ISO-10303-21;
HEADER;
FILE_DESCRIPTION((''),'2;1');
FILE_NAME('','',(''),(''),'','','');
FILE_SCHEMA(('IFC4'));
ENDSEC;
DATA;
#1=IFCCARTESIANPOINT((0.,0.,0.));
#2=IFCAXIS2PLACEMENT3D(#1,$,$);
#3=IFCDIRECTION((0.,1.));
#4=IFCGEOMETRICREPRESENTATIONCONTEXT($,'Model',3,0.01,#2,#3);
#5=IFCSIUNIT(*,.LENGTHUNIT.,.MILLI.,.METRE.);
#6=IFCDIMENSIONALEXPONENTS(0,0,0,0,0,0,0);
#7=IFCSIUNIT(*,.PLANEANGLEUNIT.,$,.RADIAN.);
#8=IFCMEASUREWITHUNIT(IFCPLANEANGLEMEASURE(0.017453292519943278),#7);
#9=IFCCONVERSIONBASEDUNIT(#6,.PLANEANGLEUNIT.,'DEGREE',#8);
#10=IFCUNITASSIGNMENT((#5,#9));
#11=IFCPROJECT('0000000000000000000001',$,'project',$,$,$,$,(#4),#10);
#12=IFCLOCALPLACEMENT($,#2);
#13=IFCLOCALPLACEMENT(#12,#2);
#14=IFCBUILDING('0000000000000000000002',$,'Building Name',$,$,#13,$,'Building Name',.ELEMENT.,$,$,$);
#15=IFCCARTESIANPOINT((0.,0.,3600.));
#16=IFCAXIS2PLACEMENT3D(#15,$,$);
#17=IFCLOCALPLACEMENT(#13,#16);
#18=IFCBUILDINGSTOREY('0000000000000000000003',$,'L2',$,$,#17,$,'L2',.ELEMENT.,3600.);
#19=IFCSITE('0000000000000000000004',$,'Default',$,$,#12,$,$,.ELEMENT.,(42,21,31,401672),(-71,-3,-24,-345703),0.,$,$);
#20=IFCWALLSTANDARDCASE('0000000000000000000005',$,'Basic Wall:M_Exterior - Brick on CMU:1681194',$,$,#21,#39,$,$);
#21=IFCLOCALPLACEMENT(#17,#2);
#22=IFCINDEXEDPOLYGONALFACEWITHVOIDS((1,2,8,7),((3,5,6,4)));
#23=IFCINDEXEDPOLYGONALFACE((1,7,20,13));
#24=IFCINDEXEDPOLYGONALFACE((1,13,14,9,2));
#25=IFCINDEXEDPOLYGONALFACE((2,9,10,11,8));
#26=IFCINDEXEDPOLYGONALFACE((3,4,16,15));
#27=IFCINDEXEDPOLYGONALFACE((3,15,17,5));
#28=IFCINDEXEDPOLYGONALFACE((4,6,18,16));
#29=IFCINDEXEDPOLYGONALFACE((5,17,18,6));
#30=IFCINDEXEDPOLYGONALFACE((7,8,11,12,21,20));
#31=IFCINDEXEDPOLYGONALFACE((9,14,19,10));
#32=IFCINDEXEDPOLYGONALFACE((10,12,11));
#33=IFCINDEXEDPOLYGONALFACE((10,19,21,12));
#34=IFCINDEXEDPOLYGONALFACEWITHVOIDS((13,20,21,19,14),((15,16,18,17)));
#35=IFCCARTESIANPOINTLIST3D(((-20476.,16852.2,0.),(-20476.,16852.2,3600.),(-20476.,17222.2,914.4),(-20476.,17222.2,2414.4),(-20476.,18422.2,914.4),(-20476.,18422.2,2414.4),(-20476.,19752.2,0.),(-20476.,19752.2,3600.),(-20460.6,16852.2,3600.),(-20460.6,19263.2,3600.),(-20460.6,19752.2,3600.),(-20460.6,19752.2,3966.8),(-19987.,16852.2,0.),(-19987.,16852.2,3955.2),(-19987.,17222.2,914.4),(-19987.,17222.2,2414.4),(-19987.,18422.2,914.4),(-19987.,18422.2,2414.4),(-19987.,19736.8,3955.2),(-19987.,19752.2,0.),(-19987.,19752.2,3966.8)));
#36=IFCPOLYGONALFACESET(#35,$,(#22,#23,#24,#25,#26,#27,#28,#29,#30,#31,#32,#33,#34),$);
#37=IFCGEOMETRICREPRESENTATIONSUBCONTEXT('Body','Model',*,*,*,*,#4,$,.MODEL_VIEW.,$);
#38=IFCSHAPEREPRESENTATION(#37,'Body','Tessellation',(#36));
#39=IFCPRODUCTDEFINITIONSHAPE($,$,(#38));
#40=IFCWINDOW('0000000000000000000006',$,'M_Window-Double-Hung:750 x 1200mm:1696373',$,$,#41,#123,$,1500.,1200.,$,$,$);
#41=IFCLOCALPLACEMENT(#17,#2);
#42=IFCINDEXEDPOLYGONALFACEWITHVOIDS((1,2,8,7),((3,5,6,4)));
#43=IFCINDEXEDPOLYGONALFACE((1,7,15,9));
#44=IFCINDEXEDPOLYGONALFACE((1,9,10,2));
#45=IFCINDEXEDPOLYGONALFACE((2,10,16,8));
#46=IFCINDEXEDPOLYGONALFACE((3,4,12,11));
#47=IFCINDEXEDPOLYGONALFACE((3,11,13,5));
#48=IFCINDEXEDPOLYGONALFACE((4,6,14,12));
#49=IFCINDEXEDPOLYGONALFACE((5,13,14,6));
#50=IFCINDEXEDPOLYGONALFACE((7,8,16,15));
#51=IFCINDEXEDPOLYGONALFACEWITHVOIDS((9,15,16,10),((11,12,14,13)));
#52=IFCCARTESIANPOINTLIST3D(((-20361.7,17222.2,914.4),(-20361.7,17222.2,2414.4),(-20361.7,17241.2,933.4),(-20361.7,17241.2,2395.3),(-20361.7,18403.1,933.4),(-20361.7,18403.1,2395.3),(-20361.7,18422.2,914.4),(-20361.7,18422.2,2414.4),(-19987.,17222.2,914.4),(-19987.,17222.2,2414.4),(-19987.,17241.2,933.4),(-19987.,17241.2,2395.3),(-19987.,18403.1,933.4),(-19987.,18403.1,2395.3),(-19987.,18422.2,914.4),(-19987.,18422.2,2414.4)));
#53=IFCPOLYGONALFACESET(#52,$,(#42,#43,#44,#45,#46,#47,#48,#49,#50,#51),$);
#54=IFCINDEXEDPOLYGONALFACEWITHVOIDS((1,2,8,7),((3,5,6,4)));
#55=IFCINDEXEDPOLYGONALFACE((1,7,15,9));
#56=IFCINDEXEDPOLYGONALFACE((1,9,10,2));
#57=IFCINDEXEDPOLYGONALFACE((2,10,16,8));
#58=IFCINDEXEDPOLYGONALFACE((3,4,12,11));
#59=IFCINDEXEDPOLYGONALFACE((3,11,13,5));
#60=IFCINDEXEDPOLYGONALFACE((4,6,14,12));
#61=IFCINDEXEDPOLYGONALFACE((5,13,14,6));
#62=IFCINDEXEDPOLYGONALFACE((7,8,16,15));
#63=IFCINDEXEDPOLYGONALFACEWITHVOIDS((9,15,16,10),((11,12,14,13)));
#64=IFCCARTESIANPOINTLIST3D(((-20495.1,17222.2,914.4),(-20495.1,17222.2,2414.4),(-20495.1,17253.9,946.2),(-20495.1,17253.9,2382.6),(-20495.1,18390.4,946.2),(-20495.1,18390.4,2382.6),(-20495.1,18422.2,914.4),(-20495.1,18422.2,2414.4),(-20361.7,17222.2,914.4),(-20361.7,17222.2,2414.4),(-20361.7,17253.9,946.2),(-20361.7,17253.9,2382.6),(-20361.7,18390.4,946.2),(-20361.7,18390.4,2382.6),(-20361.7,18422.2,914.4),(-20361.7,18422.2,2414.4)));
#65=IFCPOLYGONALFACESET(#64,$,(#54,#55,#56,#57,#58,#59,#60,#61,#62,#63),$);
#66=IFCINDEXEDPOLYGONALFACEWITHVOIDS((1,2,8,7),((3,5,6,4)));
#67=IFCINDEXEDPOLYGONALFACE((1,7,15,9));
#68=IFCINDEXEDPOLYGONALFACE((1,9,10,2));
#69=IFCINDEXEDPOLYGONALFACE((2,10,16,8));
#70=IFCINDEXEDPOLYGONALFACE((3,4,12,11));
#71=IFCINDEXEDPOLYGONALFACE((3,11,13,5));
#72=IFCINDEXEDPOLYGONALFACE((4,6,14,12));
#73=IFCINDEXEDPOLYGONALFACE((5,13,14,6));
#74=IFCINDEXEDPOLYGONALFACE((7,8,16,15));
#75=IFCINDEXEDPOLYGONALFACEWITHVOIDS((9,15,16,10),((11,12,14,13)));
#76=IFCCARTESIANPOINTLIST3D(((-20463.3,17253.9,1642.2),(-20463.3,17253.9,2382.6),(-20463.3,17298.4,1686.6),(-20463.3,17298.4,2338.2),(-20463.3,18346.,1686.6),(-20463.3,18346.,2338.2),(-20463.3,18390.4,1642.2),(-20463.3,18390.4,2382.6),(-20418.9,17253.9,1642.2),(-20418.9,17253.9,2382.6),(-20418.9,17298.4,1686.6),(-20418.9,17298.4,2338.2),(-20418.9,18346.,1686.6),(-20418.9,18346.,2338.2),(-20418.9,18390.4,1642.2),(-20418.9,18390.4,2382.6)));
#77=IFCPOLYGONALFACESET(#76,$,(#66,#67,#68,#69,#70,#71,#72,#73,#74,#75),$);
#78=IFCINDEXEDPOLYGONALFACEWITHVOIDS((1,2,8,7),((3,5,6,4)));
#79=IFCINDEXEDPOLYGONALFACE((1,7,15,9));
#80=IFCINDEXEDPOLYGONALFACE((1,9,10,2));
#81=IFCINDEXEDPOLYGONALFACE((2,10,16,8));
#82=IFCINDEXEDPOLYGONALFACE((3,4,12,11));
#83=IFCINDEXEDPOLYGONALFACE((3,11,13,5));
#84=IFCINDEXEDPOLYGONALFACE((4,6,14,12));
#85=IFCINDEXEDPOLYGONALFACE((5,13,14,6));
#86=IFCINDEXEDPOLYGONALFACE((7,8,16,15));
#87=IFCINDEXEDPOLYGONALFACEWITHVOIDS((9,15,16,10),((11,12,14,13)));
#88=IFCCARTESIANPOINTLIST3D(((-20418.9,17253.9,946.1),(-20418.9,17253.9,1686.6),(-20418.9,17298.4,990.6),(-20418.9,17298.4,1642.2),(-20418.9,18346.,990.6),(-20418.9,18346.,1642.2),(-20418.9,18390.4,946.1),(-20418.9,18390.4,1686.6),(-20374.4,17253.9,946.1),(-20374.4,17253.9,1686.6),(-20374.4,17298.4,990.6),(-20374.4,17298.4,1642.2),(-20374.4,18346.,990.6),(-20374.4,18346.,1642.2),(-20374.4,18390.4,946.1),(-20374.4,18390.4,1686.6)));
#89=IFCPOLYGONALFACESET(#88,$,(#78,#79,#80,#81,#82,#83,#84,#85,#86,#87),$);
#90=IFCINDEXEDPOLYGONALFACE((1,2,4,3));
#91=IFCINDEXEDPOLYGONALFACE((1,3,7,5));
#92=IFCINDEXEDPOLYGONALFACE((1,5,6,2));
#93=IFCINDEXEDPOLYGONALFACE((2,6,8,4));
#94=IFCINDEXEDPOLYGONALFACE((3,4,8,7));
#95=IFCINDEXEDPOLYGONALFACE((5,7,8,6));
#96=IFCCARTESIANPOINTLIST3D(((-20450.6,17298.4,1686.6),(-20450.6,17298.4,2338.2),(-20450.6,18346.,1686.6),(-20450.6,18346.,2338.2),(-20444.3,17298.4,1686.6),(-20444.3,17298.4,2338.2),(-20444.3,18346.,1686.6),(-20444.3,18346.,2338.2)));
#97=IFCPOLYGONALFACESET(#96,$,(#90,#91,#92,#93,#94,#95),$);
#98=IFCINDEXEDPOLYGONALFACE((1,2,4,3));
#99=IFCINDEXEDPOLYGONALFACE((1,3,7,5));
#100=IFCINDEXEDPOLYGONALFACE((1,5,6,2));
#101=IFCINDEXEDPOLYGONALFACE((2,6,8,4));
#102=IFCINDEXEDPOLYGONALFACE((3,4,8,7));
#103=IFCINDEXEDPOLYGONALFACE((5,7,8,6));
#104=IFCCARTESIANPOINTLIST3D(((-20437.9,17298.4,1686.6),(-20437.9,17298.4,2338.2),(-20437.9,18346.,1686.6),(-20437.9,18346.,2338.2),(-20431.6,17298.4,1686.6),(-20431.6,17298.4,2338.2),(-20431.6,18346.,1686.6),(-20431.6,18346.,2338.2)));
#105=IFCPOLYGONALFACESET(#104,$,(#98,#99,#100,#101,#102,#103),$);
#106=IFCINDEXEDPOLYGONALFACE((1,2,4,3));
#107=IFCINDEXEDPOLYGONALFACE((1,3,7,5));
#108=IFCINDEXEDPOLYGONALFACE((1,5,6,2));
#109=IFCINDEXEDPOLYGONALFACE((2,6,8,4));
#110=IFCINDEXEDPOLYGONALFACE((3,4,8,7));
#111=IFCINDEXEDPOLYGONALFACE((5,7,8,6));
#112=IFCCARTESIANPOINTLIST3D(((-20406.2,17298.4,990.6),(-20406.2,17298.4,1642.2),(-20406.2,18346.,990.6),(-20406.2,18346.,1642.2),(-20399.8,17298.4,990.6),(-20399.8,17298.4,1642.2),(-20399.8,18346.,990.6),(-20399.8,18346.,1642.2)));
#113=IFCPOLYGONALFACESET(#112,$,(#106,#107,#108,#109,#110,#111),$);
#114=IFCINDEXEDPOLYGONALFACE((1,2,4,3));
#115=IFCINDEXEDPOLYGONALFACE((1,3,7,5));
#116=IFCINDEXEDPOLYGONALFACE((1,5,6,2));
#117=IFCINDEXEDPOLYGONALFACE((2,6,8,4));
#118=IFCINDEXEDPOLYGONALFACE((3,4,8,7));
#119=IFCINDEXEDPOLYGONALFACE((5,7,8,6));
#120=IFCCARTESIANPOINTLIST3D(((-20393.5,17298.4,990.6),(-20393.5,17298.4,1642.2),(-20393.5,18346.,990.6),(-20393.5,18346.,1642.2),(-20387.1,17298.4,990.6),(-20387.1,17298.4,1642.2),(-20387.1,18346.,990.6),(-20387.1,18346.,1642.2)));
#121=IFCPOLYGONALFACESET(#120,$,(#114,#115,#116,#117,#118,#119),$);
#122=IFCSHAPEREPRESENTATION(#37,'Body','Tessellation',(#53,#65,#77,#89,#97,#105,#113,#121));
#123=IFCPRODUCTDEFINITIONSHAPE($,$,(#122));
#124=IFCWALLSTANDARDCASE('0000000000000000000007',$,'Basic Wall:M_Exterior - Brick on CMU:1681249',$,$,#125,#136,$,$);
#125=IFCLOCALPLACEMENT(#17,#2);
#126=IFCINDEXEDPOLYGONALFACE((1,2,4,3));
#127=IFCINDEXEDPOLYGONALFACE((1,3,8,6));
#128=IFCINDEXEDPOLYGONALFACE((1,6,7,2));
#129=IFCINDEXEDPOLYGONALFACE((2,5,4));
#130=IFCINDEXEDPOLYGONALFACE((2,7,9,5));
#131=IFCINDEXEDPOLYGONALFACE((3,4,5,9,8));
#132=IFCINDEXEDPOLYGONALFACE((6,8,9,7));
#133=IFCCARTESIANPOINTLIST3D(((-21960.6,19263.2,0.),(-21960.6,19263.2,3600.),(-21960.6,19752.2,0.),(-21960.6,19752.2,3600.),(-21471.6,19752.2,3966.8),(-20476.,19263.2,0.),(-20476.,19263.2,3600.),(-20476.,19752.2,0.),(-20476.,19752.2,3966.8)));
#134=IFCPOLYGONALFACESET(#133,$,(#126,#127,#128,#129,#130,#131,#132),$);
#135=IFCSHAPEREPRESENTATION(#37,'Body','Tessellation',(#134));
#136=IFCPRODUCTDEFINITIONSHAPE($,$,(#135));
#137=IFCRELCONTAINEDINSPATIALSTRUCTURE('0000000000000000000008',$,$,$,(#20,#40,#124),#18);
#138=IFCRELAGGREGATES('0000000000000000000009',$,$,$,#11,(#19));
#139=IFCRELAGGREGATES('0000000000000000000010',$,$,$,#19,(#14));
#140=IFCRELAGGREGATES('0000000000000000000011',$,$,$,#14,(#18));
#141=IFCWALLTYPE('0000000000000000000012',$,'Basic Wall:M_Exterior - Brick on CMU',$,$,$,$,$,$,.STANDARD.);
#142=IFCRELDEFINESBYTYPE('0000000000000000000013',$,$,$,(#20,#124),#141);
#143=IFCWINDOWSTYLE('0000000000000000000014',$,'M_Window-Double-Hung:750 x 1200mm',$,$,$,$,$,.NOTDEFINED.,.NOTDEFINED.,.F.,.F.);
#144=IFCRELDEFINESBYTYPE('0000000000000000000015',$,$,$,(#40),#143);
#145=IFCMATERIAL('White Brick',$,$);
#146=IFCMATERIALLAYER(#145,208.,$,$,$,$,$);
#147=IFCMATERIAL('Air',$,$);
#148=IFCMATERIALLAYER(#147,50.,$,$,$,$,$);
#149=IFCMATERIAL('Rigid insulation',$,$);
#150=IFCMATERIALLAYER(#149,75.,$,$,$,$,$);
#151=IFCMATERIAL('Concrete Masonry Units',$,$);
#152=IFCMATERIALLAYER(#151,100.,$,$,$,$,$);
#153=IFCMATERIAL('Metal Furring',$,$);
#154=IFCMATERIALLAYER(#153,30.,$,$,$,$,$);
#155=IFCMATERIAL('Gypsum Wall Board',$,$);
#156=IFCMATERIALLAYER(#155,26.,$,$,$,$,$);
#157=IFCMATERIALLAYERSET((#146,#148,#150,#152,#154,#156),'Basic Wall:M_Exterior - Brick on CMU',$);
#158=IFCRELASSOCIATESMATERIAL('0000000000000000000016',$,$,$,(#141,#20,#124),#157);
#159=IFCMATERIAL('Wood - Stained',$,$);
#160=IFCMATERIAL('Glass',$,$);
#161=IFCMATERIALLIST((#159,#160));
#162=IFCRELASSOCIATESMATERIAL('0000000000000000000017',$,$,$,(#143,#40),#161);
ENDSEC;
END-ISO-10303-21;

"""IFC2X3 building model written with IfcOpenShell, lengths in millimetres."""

from ifc_helpers import new_model, entity, si_unit, converted_unit, direction, frame, frame_2d, origin, place, context, subcontext, project, spatial, polyline, rectangle, outline, extrude, clip, bounded_halfspace, source, transform, mapped, material, material_list, layer, layer_set, layer_usage, type_object, type_shapes, element, fill, save


model = new_model("IFC2X3")

# Units and contexts
model_context = context("Model", 3, precision=0.01, world=origin(), true_north=direction((0.0, 1.0)))
body_context = subcontext(model_context, "Body", "Model", "MODEL_VIEW")
ifc_project = project(units=[si_unit("LENGTHUNIT", "METRE", prefix="MILLI"), converted_unit("PLANEANGLEUNIT", "DEGREE", entity("IfcPlaneAngleMeasure", 0.017453292519943278), si_unit("PLANEANGLEUNIT", "RADIAN"), dimensions=[0, 0, 0, 0, 0, 0, 0])], contexts=[model_context])

# Site, building, storey
site_placement = place(None, origin())
site = spatial("IfcSite", under=ifc_project, at=site_placement, Name="Default", CompositionType="ELEMENT", RefLatitude=(42, 21, 31, 401672), RefLongitude=(-71, -3, -24, -345703), RefElevation=0.0)
building_placement = place(site_placement, origin())
building = spatial("IfcBuilding", under=site, at=building_placement, Name="Building Name", LongName="Building Name", CompositionType="ELEMENT")
storey_placement = place(building_placement, frame((0.0, 0.0, 3600.0)))
storey = spatial("IfcBuildingStorey", under=building, at=storey_placement, Name="L2", LongName="L2", CompositionType="ELEMENT", Elevation=3600.0)

# Shared definitions
ifc_material_1 = material(Name="White Brick")
ifc_layer_1 = layer(ifc_material_1, 208.0)
ifc_material_2 = material(Name="Air")
ifc_layer_2 = layer(ifc_material_2, 50.0)
ifc_material_3 = material(Name="Rigid insulation")
ifc_layer_3 = layer(ifc_material_3, 75.0)
ifc_material_4 = material(Name="Concrete Masonry Units")
ifc_layer_4 = layer(ifc_material_4, 100.0)
ifc_material_5 = material(Name="Metal Furring")
ifc_layer_5 = layer(ifc_material_5, 30.0)
ifc_material_6 = material(Name="Gypsum Wall Board")
ifc_layer_6 = layer(ifc_material_6, 26.0)
ifc_layer_set_1 = layer_set([ifc_layer_1, ifc_layer_2, ifc_layer_3, ifc_layer_4, ifc_layer_5, ifc_layer_6], Name="Basic Wall:M_Exterior - Brick on CMU")
wall_type_1 = type_object("IfcWallType", Name="Basic Wall:M_Exterior - Brick on CMU", PredefinedType="STANDARD", material=ifc_layer_set_1)
ifc_material_7 = material(Name="Wood - Stained")
ifc_material_8 = material(Name="Glass")
ifc_material_list_1 = material_list([ifc_material_7, ifc_material_8])
window_style = type_object("IfcWindowStyle", Name="M_Window-Double-Hung:750 x 1200mm", ConstructionType="NOTDEFINED", OperationType="NOTDEFINED", ParameterTakesPrecedence=False, Sizeable=False, material=ifc_material_list_1)
shared_shape_1 = source(origin(), body_context, "Body", "SweptSolid", [
    extrude(outline(polyline([(-750.0, -600.0), (750.0, -600.0), (750.0, 600.0), (-750.0, 600.0), (-750.0, -600.0)]), holes=[polyline([(-730.9, -580.9), (-730.9, 580.9), (730.9, 580.9), (730.9, -580.9), (-730.9, -580.9)])]), frame((600.0, 0.0, 750.0), z_axis=(0.0, 1.0, 0.0), x_axis=(0.0, 0.0, -1.0)), (0.0, 0.0, 1.0), 374.7),
    extrude(outline(polyline([(-600.0, -750.0), (600.0, -750.0), (600.0, 750.0), (-600.0, 750.0), (-600.0, -750.0)]), holes=[polyline([(568.2, -718.2), (-568.2, -718.2), (-568.2, 718.2), (568.2, 718.2), (568.2, -718.2)])]), frame((600.0, 374.7, 750.0), z_axis=(0.0, 1.0, 0.0), x_axis=(1.0, 0.0, 0.0)), (0.0, 0.0, 1.0), 133.3),
    extrude(outline(polyline([(-568.2, -370.2), (568.2, -370.2), (568.2, 370.2), (-568.2, 370.2), (-568.2, -370.2)]), holes=[polyline([(523.8, -325.8), (-523.8, -325.8), (-523.8, 325.8), (523.8, 325.8), (523.8, -325.8)])]), frame((600.0, 431.8, 1098.0), z_axis=(0.0, 1.0, 0.0), x_axis=(1.0, 0.0, 0.0)), (0.0, 0.0, 1.0), 44.4),
    extrude(outline(polyline([(-568.2, -370.2), (568.2, -370.2), (568.2, 370.2), (-568.2, 370.2), (-568.2, -370.2)]), holes=[polyline([(523.8, -325.8), (-523.8, -325.8), (-523.8, 325.8), (523.8, 325.8), (523.8, -325.8)])]), frame((600.0, 387.4, 402.0), z_axis=(0.0, 1.0, 0.0), x_axis=(1.0, 0.0, 0.0)), (0.0, 0.0, 1.0), 44.5),
    extrude(rectangle(XDim=1047.6, YDim=6.4, at=frame_2d((0.0, 0.0), x_axis=(1.0, 0.0))), frame((600.0, 460.4, 772.2), z_axis=(0.0, 0.0, 1.0), x_axis=(-1.0, 0.0, 0.0)), (0.0, 0.0, 1.0), 651.6),
    extrude(rectangle(XDim=6.4, YDim=1047.6, at=frame_2d((0.0, 0.0), x_axis=(1.0, 0.0))), frame((600.0, 447.7, 772.2), z_axis=(0.0, 0.0, 1.0), x_axis=(0.0, -1.0, 0.0)), (0.0, 0.0, 1.0), 651.6),
    extrude(rectangle(XDim=1047.6, YDim=6.4, at=frame_2d((0.0, 0.0), x_axis=(1.0, 0.0))), frame((600.0, 416.0, 76.2), z_axis=(0.0, 0.0, 1.0), x_axis=(-1.0, 0.0, 0.0)), (0.0, 0.0, 1.0), 651.6),
    extrude(rectangle(XDim=6.4, YDim=1047.6, at=frame_2d((0.0, 0.0), x_axis=(1.0, 0.0))), frame((600.0, 403.3, 76.2), z_axis=(0.0, 0.0, 1.0), x_axis=(0.0, -1.0, 0.0)), (0.0, 0.0, 1.0), 651.6),
])
type_shapes(window_style, [shared_shape_1])

# Wall, opening, window
ifc_layer_usage_1 = layer_usage(ifc_layer_set_1, "AXIS2", "NEGATIVE", 244.5)
wall_1_placement = place(storey_placement, frame((-20231.5, 16852.2, 0.0), z_axis=(0.0, 0.0, 1.0), x_axis=(0.0, 1.0, 0.0)))
wall_1 = element("IfcWallStandardCase", 1, at=wall_1_placement, inside=storey, type_object=wall_type_1, material=ifc_layer_usage_1, Name="Basic Wall:M_Exterior - Brick on CMU:1681194", context=body_context, shape_type="Clipping", body=[
    clip(clip(clip(extrude(rectangle(XDim=2900.0, YDim=489.0, at=frame_2d((1450.0, 0.0), x_axis=(-1.0, 0.0))), origin(), (0.0, 0.0, 1.0), 3966.8), bounded_halfspace(frame((0.0, -244.5, 3955.2), z_axis=(0.0, 0.6, 0.8), x_axis=(-1.0, 0.0, 0.0)), False, frame((0.0, -244.5, 3955.2)), polyline([(0.0, 0.0), (2884.6, 0.0), (2411.0, 473.6), (0.0, 473.6), (0.0, 0.0)]))), bounded_halfspace(frame((2884.6, -244.5, 3955.2), z_axis=(-0.6, 0.0, 0.8), x_axis=(0.0, -1.0, 0.0)), False, frame((2884.6, -244.5, 3955.2)), polyline([(0.0, 0.0), (15.4, 0.0), (15.4, 473.6), (-473.6, 473.6), (0.0, 0.0)]))), bounded_halfspace(frame((2900.0, 229.1, 3600.0), z_axis=(0.0, 0.0, 1.0), x_axis=(0.0, 1.0, 0.0)), False, frame((2900.0, 229.1, 3600.0)), polyline([(0.0, 0.0), (0.0, 15.4), (-2900.0, 15.4), (-2900.0, 0.0), (-489.0, 0.0), (0.0, 0.0)]))),
])
opening_1_placement = place(wall_1_placement, frame((370.0, -244.5, 914.4)))
opening_1 = element("IfcOpeningElement", 2, at=opening_1_placement, cuts=wall_1, ObjectType="Opening", context=body_context, shape_type="SweptSolid", body=[
    extrude(rectangle(XDim=1500.0, YDim=1200.0, at=frame_2d((750.0, 600.0), x_axis=(-1.0, 0.0))), frame((0.0, 0.0, 0.0), z_axis=(0.0, 1.0, 0.0), x_axis=(0.0, 0.0, 1.0)), (0.0, 0.0, 1.0), 489.0),
])
window_1_placement = place(opening_1_placement, origin())
window_1 = element("IfcWindow", 3, at=window_1_placement, inside=storey, type_object=window_style, material=ifc_material_list_1, Name="M_Window-Double-Hung:750 x 1200mm:1696373", OverallHeight=1500.0, OverallWidth=1200.0, context=body_context, shape_type="MappedRepresentation", body=[
    mapped(shared_shape_1, transform((0.0, 0.0, 0.0), scale=1.0)),
])
fill(opening_1, window_1)

# Wall
ifc_layer_usage_2 = layer_usage(ifc_layer_set_1, "AXIS2", "NEGATIVE", 244.5)
wall_2_placement = place(storey_placement, frame((-20476.0, 19507.7, 0.0), z_axis=(0.0, 0.0, 1.0), x_axis=(-1.0, 0.0, 0.0)))
element("IfcWallStandardCase", 4, at=wall_2_placement, inside=storey, type_object=wall_type_1, material=ifc_layer_usage_2, Name="Basic Wall:M_Exterior - Brick on CMU:1681249", context=body_context, shape_type="Clipping", body=[
    clip(clip(extrude(rectangle(XDim=1484.6, YDim=489.0, at=frame_2d((742.3, 0.0), x_axis=(-1.0, 0.0))), origin(), (0.0, 0.0, 1.0), 3966.8), bounded_halfspace(frame((995.6, -244.5, 3966.8), z_axis=(0.6, 0.0, 0.8), x_axis=(0.0, 1.0, 0.0)), False, frame((995.6, -244.5, 3966.8)), polyline([(0.0, 0.0), (489.0, 0.0), (489.0, 489.0), (0.0, 0.0)]))), bounded_halfspace(frame((0.0, -244.5, 3966.8), z_axis=(0.0, 0.6, 0.8), x_axis=(-1.0, 0.0, 0.0)), False, frame((0.0, -244.5, 3966.8)), polyline([(0.0, 0.0), (995.6, 0.0), (1484.6, 489.0), (0.0, 489.0), (0.0, 0.0)]))),
])

save(model, "model.ifc")
